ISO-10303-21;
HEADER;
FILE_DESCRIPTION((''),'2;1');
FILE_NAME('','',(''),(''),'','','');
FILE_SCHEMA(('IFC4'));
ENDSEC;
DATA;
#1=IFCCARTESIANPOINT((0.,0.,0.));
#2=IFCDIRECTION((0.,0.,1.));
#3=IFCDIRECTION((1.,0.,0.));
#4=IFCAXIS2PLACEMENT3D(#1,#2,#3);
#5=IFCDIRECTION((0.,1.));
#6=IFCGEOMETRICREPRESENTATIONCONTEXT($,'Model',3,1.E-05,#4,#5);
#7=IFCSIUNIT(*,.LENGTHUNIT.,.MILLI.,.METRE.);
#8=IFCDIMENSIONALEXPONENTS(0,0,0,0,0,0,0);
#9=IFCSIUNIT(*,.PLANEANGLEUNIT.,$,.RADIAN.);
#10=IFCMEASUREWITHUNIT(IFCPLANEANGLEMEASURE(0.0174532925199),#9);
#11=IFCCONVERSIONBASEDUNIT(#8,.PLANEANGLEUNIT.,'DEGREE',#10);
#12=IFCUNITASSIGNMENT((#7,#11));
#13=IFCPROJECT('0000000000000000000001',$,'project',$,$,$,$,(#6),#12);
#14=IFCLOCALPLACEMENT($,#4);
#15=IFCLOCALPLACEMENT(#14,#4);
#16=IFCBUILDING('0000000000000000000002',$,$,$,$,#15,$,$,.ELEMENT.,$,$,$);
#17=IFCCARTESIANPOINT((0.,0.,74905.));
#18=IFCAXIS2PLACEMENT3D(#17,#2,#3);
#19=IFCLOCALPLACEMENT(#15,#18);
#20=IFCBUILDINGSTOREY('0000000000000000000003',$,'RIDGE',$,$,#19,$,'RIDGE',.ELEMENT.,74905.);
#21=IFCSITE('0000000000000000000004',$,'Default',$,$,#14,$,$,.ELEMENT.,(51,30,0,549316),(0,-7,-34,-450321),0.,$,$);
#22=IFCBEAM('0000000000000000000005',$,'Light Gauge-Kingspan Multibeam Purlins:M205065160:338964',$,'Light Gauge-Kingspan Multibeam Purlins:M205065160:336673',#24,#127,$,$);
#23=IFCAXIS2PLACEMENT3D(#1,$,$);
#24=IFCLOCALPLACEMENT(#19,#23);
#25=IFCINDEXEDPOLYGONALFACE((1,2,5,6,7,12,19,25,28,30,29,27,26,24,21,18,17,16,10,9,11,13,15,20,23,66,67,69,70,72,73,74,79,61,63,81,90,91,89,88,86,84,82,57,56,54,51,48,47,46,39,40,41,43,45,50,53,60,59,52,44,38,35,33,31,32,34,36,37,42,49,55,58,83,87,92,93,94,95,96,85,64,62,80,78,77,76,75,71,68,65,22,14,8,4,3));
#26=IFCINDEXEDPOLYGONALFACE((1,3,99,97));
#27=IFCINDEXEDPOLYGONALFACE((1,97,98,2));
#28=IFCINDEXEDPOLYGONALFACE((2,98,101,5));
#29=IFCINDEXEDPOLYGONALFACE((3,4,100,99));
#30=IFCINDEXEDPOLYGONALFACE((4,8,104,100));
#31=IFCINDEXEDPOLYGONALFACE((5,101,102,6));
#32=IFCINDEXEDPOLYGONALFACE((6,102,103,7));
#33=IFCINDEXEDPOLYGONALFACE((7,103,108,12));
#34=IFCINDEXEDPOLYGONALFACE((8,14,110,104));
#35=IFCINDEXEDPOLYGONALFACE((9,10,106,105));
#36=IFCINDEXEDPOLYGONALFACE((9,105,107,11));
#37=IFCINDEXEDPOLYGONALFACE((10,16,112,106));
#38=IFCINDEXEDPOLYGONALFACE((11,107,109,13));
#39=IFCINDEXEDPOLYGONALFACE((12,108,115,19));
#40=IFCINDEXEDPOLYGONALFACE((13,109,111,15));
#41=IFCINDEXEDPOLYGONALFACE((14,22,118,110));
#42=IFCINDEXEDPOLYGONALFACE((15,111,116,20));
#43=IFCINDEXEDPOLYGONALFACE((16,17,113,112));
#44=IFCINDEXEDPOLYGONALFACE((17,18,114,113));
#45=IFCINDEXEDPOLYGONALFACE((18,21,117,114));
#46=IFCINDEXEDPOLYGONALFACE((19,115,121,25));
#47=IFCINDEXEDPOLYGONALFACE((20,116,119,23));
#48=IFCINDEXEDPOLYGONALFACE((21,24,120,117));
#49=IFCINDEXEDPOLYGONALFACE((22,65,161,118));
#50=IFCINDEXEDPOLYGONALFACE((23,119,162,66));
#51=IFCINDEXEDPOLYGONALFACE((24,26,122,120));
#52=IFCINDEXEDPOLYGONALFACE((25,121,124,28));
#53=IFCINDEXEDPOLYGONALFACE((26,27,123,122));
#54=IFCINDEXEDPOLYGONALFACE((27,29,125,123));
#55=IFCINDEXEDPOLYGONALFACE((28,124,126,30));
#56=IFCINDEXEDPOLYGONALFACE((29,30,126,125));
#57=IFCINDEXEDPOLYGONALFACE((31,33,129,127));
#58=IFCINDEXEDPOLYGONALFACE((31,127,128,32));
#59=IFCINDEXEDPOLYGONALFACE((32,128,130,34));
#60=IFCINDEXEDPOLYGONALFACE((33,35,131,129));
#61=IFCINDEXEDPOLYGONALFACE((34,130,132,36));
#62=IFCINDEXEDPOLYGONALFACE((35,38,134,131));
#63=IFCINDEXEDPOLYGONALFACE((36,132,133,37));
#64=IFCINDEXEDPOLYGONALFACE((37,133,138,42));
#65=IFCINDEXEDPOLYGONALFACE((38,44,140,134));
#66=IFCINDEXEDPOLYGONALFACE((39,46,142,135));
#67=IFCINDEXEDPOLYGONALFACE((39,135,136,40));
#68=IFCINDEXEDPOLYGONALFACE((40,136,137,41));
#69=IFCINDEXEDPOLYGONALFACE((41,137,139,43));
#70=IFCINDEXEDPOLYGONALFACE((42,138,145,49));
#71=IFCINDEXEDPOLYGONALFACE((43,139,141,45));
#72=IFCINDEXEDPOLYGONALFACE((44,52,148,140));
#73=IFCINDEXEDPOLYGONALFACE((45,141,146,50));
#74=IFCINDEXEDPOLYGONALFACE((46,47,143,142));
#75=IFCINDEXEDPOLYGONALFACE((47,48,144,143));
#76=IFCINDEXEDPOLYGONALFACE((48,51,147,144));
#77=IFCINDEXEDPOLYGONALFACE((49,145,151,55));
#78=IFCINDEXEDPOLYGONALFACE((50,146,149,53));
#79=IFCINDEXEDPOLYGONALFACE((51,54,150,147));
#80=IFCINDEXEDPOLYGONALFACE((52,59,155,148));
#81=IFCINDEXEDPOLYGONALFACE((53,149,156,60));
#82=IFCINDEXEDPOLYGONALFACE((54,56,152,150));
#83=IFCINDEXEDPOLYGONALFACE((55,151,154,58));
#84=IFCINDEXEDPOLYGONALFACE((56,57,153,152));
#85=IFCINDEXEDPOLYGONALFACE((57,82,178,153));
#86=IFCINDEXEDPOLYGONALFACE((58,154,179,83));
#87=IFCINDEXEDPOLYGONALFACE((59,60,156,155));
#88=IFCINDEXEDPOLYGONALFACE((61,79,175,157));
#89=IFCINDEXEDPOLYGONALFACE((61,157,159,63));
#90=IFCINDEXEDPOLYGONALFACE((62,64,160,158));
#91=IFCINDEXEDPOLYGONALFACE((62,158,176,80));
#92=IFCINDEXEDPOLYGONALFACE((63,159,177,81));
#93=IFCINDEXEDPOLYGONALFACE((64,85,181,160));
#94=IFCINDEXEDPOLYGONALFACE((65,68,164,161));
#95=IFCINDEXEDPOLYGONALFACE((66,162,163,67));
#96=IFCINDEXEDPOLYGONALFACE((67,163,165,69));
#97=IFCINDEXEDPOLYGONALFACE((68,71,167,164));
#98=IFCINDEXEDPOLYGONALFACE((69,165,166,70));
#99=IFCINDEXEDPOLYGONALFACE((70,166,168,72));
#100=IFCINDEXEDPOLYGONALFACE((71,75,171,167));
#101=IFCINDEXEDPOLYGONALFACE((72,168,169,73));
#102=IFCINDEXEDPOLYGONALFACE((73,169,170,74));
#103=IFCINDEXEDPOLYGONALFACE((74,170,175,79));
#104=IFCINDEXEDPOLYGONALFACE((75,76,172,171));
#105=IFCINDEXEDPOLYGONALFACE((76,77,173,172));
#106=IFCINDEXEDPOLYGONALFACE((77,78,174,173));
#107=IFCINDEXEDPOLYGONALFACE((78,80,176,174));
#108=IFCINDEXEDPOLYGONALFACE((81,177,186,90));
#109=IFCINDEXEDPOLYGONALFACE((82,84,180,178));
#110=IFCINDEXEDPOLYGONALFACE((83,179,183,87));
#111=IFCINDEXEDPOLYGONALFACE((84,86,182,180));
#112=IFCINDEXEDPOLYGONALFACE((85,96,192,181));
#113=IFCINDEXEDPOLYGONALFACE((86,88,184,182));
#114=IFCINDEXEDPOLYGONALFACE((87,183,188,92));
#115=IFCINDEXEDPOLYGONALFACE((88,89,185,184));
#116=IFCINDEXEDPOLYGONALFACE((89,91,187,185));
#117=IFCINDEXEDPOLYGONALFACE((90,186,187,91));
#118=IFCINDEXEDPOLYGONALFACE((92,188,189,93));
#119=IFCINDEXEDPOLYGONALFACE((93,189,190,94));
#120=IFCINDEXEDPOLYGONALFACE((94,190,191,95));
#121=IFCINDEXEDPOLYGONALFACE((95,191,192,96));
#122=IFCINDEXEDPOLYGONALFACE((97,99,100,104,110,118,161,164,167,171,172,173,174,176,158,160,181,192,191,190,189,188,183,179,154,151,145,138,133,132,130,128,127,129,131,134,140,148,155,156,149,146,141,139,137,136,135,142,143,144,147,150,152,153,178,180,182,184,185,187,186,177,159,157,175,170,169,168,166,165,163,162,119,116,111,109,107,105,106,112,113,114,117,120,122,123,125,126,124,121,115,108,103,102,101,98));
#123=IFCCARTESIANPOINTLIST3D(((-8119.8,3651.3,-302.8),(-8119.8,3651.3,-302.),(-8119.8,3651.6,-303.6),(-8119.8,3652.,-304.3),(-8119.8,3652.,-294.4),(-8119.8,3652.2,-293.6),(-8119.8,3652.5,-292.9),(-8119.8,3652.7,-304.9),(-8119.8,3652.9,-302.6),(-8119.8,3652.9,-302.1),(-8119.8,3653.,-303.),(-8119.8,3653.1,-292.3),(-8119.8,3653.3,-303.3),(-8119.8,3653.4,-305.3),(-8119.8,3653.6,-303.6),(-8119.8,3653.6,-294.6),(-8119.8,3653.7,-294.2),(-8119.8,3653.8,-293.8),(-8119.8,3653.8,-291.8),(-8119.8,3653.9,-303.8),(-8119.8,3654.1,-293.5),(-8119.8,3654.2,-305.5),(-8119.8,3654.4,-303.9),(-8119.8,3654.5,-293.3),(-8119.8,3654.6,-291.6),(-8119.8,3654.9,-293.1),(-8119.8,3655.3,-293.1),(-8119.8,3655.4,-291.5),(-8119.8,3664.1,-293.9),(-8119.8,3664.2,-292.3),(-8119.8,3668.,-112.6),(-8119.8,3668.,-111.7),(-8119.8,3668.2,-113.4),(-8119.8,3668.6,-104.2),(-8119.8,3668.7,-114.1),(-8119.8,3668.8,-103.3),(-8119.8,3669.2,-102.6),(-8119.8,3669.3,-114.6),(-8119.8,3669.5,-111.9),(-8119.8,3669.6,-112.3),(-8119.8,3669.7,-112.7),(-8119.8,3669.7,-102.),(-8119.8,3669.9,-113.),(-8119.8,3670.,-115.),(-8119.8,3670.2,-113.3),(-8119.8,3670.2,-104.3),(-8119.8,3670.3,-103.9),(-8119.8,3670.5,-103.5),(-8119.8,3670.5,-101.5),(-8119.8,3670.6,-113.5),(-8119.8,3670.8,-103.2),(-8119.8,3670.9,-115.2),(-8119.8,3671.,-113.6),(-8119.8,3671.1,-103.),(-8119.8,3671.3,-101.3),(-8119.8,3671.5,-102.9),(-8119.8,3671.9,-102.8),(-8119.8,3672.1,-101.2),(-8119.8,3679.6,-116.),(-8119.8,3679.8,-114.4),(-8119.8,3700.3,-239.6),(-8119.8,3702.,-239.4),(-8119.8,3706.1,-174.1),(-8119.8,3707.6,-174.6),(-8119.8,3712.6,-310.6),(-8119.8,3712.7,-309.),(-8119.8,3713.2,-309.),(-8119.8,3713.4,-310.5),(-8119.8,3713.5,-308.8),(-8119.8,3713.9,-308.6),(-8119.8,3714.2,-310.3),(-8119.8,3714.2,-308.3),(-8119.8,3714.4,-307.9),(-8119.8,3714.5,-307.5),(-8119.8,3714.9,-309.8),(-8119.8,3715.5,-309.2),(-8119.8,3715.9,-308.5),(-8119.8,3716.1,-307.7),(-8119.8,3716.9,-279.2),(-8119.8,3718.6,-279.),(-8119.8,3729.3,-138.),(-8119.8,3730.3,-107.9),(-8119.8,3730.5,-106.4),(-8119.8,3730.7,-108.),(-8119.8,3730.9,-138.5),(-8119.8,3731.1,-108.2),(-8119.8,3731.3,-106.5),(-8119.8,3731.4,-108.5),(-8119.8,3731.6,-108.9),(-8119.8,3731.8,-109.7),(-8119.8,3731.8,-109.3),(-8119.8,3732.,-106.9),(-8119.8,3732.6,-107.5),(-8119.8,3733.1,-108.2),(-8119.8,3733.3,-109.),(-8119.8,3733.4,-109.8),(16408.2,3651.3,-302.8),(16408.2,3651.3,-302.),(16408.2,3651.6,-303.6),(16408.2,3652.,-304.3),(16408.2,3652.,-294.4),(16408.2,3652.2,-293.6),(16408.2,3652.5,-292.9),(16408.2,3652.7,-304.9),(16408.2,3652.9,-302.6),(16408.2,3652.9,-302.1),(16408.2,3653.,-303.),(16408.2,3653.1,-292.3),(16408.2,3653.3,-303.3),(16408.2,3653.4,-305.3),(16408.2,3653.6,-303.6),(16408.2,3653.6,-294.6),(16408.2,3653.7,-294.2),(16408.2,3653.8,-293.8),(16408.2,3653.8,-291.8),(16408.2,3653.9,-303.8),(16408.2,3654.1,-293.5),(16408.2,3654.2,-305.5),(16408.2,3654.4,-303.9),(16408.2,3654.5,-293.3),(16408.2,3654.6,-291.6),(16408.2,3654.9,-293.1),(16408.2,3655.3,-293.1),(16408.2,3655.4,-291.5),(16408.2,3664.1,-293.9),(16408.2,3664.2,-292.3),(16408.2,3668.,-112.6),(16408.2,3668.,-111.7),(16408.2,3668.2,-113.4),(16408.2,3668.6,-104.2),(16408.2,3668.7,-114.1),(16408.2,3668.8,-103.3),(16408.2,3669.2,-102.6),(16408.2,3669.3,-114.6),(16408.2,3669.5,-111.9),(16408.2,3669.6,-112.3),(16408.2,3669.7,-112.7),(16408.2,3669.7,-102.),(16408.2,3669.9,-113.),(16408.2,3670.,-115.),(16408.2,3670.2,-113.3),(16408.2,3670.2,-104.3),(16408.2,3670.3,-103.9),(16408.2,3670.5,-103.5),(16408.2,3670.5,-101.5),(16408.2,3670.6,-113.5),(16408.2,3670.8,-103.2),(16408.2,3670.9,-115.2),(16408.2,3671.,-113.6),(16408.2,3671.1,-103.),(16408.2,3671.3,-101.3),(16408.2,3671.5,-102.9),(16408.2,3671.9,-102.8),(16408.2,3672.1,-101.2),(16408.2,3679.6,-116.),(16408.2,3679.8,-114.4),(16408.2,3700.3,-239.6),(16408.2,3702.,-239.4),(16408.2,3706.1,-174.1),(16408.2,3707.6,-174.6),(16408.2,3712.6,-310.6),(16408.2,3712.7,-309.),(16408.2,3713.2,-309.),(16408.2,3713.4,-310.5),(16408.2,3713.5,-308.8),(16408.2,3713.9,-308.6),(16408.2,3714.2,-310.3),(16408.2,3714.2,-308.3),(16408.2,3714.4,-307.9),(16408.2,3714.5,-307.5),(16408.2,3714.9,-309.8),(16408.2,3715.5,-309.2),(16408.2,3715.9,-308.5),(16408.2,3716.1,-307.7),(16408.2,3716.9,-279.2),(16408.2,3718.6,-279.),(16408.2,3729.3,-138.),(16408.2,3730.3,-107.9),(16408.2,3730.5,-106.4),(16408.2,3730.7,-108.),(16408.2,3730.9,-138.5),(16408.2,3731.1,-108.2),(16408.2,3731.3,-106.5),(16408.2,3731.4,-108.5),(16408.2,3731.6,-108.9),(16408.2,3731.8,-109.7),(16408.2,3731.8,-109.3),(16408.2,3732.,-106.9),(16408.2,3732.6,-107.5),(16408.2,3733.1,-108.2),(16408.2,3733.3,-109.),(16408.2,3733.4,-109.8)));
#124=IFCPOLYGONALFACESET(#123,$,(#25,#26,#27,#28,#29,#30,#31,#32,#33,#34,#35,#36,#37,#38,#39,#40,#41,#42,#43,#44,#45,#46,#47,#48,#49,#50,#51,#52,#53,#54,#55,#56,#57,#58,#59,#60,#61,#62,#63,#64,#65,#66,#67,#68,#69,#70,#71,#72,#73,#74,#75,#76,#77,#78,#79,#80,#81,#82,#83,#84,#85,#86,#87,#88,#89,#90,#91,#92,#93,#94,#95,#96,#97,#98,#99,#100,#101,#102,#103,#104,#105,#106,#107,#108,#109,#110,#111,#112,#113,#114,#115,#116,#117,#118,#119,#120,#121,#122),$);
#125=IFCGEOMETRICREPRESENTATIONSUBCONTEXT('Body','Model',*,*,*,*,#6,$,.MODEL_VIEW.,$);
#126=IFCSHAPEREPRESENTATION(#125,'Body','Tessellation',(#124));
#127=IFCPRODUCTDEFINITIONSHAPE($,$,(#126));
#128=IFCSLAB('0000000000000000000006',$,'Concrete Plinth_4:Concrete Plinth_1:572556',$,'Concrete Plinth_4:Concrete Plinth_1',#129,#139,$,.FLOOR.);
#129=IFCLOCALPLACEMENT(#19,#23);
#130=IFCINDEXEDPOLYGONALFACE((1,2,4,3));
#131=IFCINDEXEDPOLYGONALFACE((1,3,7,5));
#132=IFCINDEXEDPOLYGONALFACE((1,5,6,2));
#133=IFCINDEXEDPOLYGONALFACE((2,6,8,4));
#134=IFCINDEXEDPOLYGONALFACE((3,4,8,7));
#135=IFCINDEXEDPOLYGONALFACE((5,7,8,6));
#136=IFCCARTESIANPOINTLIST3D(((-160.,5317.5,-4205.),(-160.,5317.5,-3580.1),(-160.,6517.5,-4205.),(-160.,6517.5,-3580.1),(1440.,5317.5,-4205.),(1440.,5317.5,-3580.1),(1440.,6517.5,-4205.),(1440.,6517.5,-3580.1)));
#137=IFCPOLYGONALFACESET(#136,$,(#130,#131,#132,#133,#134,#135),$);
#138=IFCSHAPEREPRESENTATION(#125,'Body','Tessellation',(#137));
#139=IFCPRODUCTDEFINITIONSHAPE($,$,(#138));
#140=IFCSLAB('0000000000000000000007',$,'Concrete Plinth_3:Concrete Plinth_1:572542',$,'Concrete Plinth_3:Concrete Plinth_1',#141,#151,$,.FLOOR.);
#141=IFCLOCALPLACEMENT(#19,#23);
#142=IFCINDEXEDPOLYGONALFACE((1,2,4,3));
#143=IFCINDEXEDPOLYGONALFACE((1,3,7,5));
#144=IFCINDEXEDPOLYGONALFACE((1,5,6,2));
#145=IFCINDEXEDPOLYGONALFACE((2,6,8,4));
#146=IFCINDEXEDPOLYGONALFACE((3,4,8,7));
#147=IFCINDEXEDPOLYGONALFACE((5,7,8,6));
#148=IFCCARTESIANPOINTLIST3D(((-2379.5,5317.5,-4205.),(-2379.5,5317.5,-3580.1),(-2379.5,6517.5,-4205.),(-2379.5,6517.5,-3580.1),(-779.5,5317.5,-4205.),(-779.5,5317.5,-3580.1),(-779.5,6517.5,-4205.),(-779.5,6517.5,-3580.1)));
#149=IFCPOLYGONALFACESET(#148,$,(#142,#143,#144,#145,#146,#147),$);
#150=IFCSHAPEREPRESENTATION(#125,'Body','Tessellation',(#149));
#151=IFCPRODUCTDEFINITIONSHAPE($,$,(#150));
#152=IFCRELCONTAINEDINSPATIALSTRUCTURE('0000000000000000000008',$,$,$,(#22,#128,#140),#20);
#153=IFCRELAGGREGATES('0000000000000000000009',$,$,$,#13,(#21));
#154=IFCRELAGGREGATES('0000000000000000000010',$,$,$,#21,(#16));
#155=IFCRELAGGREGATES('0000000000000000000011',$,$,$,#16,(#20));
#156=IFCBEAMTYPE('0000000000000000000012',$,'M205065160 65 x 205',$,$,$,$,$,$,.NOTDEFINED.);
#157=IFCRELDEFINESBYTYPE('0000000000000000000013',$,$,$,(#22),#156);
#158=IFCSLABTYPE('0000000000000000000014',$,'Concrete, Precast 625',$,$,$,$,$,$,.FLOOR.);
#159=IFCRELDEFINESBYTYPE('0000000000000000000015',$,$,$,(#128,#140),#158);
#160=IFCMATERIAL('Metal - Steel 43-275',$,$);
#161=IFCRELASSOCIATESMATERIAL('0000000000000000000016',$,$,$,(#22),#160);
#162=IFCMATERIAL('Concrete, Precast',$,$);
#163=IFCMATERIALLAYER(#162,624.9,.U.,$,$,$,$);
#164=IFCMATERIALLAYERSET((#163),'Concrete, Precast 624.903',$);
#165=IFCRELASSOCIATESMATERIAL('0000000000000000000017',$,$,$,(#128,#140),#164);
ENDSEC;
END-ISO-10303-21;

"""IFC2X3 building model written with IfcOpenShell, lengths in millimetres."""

from ifc_helpers import new_model, entity, si_unit, converted_unit, point, direction, frame, frame_2d, origin_with_axes, place, context, subcontext, project, spatial, polyline, circle_curve, parameter, trimmed, segment, composite_curve, outline, extrude, material, layer, layer_set, layer_usage, type_object, element, save


model = new_model("IFC2X3")

# Units and contexts
model_context = context("Model", 3, precision=1e-05, world=origin_with_axes(), true_north=direction((0.0, 1.0)))
body_context = subcontext(model_context, "Body", "Model", "MODEL_VIEW")
ifc_project = project(units=[si_unit("LENGTHUNIT", "METRE", prefix="MILLI"), converted_unit("PLANEANGLEUNIT", "DEGREE", entity("IfcPlaneAngleMeasure", 0.0174532925199), si_unit("PLANEANGLEUNIT", "RADIAN"), dimensions=[0, 0, 0, 0, 0, 0, 0])], contexts=[model_context])

# Site, building, storey
site_placement = place(None, origin_with_axes())
site = spatial("IfcSite", under=ifc_project, at=site_placement, Name="Default", CompositionType="ELEMENT", RefLatitude=(51, 30, 0, 549316), RefLongitude=(0, -7, -34, -450321), RefElevation=0.0)
building_placement = place(site_placement, origin_with_axes())
building = spatial("IfcBuilding", under=site, at=building_placement, CompositionType="ELEMENT")
storey_placement = place(building_placement, frame((0.0, 0.0, 74905.0), z_axis=(0.0, 0.0, 1.0), x_axis=(1.0, 0.0, 0.0)))
storey = spatial("IfcBuildingStorey", under=building, at=storey_placement, Name="RIDGE", LongName="RIDGE", CompositionType="ELEMENT", Elevation=74905.0)

# Beam
ifc_material_1 = material(Name="Metal - Steel 43-275")
beam_type_1 = type_object("IfcBeamType", Name="M205065160 65 x 205", PredefinedType="NOTDEFINED")
beam_1_placement = place(storey_placement, frame((16408.2, 3688.1, -205.5), z_axis=(0.0, 0.0, 1.0), x_axis=(0.0, 1.0, 0.0)))
element("IfcBeam", 1, at=beam_1_placement, inside=storey, type_object=beam_type_1, material=ifc_material_1, Name="Light Gauge-Kingspan Multibeam Purlins:M205065160:338964", ObjectType="Light Gauge-Kingspan Multibeam Purlins:M205065160:336673", context=body_context, shape_type="SweptSolid", body=[
    extrude(outline(composite_curve([segment(polyline([(-33.5, -102.5), (25.1, -102.5)]), True, "CONTINUOUS"), segment(trimmed(circle_curve(frame_2d((25.1, -99.3), x_axis=(0.0, -1.0)), 3.2), [point((25.1, -102.5)), parameter(0.0)], [point((28.3, -99.3)), parameter(90.0)], True, "CARTESIAN"), True, "CONTINUOUS"), segment(polyline([(28.3, -99.3), (28.3, -91.7)]), True, "CONTINUOUS"), segment(trimmed(circle_curve(frame_2d((25.1, -91.7), x_axis=(1.0, 0.0)), 3.2), [point((28.3, -91.7)), parameter(0.0)], [point((25.1, -88.5)), parameter(90.0)], True, "CARTESIAN"), True, "CONTINUOUS"), segment(polyline([(25.1, -88.5), (16.3, -88.5), (16.3, -90.1), (25.1, -90.1)]), True, "CONTINUOUS"), segment(trimmed(circle_curve(frame_2d((25.1, -91.7), x_axis=(1.0, 0.0)), 1.6), [point((25.1, -90.1)), parameter(90.0)], [point((26.7, -91.7)), parameter(0.0)], False, "CARTESIAN"), True, "CONTINUOUS"), segment(polyline([(26.7, -91.7), (26.7, -99.3)]), True, "CONTINUOUS"), segment(trimmed(circle_curve(frame_2d((25.1, -99.3), x_axis=(0.0, -1.0)), 1.6), [point((26.7, -99.3)), parameter(90.0)], [point((25.1, -100.9)), parameter(0.0)], False, "CARTESIAN"), True, "CONTINUOUS"), segment(polyline([(25.1, -100.9), (-33.5, -100.9)]), True, "CONTINUOUS"), segment(trimmed(circle_curve(frame_2d((-33.5, -99.3), x_axis=(-1.0, 0.0)), 1.6), [point((-33.5, -100.9)), parameter(90.0)], [point((-35.1, -99.3)), parameter(0.0)], False, "CARTESIAN"), True, "CONTINUOUS"), segment(polyline([(-35.1, -99.3), (-35.1, -70.9), (-15.1, -32.9), (-15.1, 32.9), (-35.1, 70.9), (-35.1, 99.3)]), True, "CONTINUOUS"), segment(trimmed(circle_curve(frame_2d((-33.5, 99.3), x_axis=(0.0, 1.0)), 1.6), [point((-35.1, 99.3)), parameter(90.0)], [point((-33.5, 100.9)), parameter(0.0)], False, "CARTESIAN"), True, "CONTINUOUS"), segment(polyline([(-33.5, 100.9), (25.1, 100.9)]), True, "CONTINUOUS"), segment(trimmed(circle_curve(frame_2d((25.1, 99.3), x_axis=(1.0, 0.0)), 1.6), [point((25.1, 100.9)), parameter(90.0)], [point((26.7, 99.3)), parameter(0.0)], False, "CARTESIAN"), True, "CONTINUOUS"), segment(polyline([(26.7, 99.3), (26.7, 91.7)]), True, "CONTINUOUS"), segment(trimmed(circle_curve(frame_2d((25.1, 91.7), x_axis=(0.0, -1.0)), 1.6), [point((26.7, 91.7)), parameter(90.0)], [point((25.1, 90.1)), parameter(0.0)], False, "CARTESIAN"), True, "CONTINUOUS"), segment(polyline([(25.1, 90.1), (16.3, 90.1), (16.3, 88.5), (25.1, 88.5)]), True, "CONTINUOUS"), segment(trimmed(circle_curve(frame_2d((25.1, 91.7), x_axis=(0.0, -1.0)), 3.2), [point((25.1, 88.5)), parameter(0.0)], [point((28.3, 91.7)), parameter(90.0)], True, "CARTESIAN"), True, "CONTINUOUS"), segment(polyline([(28.3, 91.7), (28.3, 99.3)]), True, "CONTINUOUS"), segment(trimmed(circle_curve(frame_2d((25.1, 99.3), x_axis=(1.0, 0.0)), 3.2), [point((28.3, 99.3)), parameter(0.0)], [point((25.1, 102.5)), parameter(90.0)], True, "CARTESIAN"), True, "CONTINUOUS"), segment(polyline([(25.1, 102.5), (-33.5, 102.5)]), True, "CONTINUOUS"), segment(trimmed(circle_curve(frame_2d((-33.5, 99.3), x_axis=(0.0, 1.0)), 3.2), [point((-33.5, 102.5)), parameter(0.0)], [point((-36.7, 99.3)), parameter(90.0)], True, "CARTESIAN"), True, "CONTINUOUS"), segment(polyline([(-36.7, 99.3), (-36.7, 70.5), (-16.7, 32.5), (-16.7, -32.5), (-36.7, -70.5), (-36.7, -99.3)]), True, "CONTINUOUS"), segment(trimmed(circle_curve(frame_2d((-33.5, -99.3), x_axis=(-1.0, 0.0)), 3.2), [point((-36.7, -99.3)), parameter(0.0)], [point((-33.5, -102.5)), parameter(90.0)], True, "CARTESIAN"), True, "CONTINUOUS")], self_intersect=False)), frame((0.0, 24528.0, 0.0), z_axis=(0.0, -1.0, 0.0), x_axis=(-0.996195, 0.0, 0.087156)), (0.0, 0.0, 1.0), 24528.0),
])

# Slabs
ifc_material_2 = material(Name="Concrete, Precast")
ifc_layer = layer(ifc_material_2, 624.9, ventilated="UNKNOWN")
ifc_layer_set = layer_set([ifc_layer], Name="Concrete, Precast 624.903")
ifc_layer_usage_1 = layer_usage(ifc_layer_set, "AXIS3", "NEGATIVE", 624.9)
slab_type = type_object("IfcSlabType", Name="Concrete, Precast 625", PredefinedType="FLOOR")
slab_1_placement = place(storey_placement, frame((-160.0, 6517.5, -4205.0), z_axis=(0.0, 0.0, 1.0), x_axis=(1.0, 0.0, 0.0)))
element("IfcSlab", 2, at=slab_1_placement, inside=storey, type_object=slab_type, material=ifc_layer_usage_1, Name="Concrete Plinth_4:Concrete Plinth_1:572556", ObjectType="Concrete Plinth_4:Concrete Plinth_1", PredefinedType="FLOOR", context=body_context, shape_type="SweptSolid", body=[
    extrude(outline(polyline([(0.0, 0.0), (0.0, -1200.0), (1600.0, -1200.0), (1600.0, 0.0), (0.0, 0.0)])), origin_with_axes(), (0.0, 0.0, 1.0), 624.9),
])
ifc_layer_usage_2 = layer_usage(ifc_layer_set, "AXIS3", "NEGATIVE", 624.9)
slab_2_placement = place(storey_placement, frame((-2379.5, 6517.5, -4205.0), z_axis=(0.0, 0.0, 1.0), x_axis=(1.0, 0.0, 0.0)))
element("IfcSlab", 3, at=slab_2_placement, inside=storey, type_object=slab_type, material=ifc_layer_usage_2, Name="Concrete Plinth_3:Concrete Plinth_1:572542", ObjectType="Concrete Plinth_3:Concrete Plinth_1", PredefinedType="FLOOR", context=body_context, shape_type="SweptSolid", body=[
    extrude(outline(polyline([(0.0, 0.0), (0.0, -1200.0), (1600.0, -1200.0), (1600.0, 0.0), (0.0, 0.0)])), origin_with_axes(), (0.0, 0.0, 1.0), 624.9),
])

save(model, "model.ifc")
